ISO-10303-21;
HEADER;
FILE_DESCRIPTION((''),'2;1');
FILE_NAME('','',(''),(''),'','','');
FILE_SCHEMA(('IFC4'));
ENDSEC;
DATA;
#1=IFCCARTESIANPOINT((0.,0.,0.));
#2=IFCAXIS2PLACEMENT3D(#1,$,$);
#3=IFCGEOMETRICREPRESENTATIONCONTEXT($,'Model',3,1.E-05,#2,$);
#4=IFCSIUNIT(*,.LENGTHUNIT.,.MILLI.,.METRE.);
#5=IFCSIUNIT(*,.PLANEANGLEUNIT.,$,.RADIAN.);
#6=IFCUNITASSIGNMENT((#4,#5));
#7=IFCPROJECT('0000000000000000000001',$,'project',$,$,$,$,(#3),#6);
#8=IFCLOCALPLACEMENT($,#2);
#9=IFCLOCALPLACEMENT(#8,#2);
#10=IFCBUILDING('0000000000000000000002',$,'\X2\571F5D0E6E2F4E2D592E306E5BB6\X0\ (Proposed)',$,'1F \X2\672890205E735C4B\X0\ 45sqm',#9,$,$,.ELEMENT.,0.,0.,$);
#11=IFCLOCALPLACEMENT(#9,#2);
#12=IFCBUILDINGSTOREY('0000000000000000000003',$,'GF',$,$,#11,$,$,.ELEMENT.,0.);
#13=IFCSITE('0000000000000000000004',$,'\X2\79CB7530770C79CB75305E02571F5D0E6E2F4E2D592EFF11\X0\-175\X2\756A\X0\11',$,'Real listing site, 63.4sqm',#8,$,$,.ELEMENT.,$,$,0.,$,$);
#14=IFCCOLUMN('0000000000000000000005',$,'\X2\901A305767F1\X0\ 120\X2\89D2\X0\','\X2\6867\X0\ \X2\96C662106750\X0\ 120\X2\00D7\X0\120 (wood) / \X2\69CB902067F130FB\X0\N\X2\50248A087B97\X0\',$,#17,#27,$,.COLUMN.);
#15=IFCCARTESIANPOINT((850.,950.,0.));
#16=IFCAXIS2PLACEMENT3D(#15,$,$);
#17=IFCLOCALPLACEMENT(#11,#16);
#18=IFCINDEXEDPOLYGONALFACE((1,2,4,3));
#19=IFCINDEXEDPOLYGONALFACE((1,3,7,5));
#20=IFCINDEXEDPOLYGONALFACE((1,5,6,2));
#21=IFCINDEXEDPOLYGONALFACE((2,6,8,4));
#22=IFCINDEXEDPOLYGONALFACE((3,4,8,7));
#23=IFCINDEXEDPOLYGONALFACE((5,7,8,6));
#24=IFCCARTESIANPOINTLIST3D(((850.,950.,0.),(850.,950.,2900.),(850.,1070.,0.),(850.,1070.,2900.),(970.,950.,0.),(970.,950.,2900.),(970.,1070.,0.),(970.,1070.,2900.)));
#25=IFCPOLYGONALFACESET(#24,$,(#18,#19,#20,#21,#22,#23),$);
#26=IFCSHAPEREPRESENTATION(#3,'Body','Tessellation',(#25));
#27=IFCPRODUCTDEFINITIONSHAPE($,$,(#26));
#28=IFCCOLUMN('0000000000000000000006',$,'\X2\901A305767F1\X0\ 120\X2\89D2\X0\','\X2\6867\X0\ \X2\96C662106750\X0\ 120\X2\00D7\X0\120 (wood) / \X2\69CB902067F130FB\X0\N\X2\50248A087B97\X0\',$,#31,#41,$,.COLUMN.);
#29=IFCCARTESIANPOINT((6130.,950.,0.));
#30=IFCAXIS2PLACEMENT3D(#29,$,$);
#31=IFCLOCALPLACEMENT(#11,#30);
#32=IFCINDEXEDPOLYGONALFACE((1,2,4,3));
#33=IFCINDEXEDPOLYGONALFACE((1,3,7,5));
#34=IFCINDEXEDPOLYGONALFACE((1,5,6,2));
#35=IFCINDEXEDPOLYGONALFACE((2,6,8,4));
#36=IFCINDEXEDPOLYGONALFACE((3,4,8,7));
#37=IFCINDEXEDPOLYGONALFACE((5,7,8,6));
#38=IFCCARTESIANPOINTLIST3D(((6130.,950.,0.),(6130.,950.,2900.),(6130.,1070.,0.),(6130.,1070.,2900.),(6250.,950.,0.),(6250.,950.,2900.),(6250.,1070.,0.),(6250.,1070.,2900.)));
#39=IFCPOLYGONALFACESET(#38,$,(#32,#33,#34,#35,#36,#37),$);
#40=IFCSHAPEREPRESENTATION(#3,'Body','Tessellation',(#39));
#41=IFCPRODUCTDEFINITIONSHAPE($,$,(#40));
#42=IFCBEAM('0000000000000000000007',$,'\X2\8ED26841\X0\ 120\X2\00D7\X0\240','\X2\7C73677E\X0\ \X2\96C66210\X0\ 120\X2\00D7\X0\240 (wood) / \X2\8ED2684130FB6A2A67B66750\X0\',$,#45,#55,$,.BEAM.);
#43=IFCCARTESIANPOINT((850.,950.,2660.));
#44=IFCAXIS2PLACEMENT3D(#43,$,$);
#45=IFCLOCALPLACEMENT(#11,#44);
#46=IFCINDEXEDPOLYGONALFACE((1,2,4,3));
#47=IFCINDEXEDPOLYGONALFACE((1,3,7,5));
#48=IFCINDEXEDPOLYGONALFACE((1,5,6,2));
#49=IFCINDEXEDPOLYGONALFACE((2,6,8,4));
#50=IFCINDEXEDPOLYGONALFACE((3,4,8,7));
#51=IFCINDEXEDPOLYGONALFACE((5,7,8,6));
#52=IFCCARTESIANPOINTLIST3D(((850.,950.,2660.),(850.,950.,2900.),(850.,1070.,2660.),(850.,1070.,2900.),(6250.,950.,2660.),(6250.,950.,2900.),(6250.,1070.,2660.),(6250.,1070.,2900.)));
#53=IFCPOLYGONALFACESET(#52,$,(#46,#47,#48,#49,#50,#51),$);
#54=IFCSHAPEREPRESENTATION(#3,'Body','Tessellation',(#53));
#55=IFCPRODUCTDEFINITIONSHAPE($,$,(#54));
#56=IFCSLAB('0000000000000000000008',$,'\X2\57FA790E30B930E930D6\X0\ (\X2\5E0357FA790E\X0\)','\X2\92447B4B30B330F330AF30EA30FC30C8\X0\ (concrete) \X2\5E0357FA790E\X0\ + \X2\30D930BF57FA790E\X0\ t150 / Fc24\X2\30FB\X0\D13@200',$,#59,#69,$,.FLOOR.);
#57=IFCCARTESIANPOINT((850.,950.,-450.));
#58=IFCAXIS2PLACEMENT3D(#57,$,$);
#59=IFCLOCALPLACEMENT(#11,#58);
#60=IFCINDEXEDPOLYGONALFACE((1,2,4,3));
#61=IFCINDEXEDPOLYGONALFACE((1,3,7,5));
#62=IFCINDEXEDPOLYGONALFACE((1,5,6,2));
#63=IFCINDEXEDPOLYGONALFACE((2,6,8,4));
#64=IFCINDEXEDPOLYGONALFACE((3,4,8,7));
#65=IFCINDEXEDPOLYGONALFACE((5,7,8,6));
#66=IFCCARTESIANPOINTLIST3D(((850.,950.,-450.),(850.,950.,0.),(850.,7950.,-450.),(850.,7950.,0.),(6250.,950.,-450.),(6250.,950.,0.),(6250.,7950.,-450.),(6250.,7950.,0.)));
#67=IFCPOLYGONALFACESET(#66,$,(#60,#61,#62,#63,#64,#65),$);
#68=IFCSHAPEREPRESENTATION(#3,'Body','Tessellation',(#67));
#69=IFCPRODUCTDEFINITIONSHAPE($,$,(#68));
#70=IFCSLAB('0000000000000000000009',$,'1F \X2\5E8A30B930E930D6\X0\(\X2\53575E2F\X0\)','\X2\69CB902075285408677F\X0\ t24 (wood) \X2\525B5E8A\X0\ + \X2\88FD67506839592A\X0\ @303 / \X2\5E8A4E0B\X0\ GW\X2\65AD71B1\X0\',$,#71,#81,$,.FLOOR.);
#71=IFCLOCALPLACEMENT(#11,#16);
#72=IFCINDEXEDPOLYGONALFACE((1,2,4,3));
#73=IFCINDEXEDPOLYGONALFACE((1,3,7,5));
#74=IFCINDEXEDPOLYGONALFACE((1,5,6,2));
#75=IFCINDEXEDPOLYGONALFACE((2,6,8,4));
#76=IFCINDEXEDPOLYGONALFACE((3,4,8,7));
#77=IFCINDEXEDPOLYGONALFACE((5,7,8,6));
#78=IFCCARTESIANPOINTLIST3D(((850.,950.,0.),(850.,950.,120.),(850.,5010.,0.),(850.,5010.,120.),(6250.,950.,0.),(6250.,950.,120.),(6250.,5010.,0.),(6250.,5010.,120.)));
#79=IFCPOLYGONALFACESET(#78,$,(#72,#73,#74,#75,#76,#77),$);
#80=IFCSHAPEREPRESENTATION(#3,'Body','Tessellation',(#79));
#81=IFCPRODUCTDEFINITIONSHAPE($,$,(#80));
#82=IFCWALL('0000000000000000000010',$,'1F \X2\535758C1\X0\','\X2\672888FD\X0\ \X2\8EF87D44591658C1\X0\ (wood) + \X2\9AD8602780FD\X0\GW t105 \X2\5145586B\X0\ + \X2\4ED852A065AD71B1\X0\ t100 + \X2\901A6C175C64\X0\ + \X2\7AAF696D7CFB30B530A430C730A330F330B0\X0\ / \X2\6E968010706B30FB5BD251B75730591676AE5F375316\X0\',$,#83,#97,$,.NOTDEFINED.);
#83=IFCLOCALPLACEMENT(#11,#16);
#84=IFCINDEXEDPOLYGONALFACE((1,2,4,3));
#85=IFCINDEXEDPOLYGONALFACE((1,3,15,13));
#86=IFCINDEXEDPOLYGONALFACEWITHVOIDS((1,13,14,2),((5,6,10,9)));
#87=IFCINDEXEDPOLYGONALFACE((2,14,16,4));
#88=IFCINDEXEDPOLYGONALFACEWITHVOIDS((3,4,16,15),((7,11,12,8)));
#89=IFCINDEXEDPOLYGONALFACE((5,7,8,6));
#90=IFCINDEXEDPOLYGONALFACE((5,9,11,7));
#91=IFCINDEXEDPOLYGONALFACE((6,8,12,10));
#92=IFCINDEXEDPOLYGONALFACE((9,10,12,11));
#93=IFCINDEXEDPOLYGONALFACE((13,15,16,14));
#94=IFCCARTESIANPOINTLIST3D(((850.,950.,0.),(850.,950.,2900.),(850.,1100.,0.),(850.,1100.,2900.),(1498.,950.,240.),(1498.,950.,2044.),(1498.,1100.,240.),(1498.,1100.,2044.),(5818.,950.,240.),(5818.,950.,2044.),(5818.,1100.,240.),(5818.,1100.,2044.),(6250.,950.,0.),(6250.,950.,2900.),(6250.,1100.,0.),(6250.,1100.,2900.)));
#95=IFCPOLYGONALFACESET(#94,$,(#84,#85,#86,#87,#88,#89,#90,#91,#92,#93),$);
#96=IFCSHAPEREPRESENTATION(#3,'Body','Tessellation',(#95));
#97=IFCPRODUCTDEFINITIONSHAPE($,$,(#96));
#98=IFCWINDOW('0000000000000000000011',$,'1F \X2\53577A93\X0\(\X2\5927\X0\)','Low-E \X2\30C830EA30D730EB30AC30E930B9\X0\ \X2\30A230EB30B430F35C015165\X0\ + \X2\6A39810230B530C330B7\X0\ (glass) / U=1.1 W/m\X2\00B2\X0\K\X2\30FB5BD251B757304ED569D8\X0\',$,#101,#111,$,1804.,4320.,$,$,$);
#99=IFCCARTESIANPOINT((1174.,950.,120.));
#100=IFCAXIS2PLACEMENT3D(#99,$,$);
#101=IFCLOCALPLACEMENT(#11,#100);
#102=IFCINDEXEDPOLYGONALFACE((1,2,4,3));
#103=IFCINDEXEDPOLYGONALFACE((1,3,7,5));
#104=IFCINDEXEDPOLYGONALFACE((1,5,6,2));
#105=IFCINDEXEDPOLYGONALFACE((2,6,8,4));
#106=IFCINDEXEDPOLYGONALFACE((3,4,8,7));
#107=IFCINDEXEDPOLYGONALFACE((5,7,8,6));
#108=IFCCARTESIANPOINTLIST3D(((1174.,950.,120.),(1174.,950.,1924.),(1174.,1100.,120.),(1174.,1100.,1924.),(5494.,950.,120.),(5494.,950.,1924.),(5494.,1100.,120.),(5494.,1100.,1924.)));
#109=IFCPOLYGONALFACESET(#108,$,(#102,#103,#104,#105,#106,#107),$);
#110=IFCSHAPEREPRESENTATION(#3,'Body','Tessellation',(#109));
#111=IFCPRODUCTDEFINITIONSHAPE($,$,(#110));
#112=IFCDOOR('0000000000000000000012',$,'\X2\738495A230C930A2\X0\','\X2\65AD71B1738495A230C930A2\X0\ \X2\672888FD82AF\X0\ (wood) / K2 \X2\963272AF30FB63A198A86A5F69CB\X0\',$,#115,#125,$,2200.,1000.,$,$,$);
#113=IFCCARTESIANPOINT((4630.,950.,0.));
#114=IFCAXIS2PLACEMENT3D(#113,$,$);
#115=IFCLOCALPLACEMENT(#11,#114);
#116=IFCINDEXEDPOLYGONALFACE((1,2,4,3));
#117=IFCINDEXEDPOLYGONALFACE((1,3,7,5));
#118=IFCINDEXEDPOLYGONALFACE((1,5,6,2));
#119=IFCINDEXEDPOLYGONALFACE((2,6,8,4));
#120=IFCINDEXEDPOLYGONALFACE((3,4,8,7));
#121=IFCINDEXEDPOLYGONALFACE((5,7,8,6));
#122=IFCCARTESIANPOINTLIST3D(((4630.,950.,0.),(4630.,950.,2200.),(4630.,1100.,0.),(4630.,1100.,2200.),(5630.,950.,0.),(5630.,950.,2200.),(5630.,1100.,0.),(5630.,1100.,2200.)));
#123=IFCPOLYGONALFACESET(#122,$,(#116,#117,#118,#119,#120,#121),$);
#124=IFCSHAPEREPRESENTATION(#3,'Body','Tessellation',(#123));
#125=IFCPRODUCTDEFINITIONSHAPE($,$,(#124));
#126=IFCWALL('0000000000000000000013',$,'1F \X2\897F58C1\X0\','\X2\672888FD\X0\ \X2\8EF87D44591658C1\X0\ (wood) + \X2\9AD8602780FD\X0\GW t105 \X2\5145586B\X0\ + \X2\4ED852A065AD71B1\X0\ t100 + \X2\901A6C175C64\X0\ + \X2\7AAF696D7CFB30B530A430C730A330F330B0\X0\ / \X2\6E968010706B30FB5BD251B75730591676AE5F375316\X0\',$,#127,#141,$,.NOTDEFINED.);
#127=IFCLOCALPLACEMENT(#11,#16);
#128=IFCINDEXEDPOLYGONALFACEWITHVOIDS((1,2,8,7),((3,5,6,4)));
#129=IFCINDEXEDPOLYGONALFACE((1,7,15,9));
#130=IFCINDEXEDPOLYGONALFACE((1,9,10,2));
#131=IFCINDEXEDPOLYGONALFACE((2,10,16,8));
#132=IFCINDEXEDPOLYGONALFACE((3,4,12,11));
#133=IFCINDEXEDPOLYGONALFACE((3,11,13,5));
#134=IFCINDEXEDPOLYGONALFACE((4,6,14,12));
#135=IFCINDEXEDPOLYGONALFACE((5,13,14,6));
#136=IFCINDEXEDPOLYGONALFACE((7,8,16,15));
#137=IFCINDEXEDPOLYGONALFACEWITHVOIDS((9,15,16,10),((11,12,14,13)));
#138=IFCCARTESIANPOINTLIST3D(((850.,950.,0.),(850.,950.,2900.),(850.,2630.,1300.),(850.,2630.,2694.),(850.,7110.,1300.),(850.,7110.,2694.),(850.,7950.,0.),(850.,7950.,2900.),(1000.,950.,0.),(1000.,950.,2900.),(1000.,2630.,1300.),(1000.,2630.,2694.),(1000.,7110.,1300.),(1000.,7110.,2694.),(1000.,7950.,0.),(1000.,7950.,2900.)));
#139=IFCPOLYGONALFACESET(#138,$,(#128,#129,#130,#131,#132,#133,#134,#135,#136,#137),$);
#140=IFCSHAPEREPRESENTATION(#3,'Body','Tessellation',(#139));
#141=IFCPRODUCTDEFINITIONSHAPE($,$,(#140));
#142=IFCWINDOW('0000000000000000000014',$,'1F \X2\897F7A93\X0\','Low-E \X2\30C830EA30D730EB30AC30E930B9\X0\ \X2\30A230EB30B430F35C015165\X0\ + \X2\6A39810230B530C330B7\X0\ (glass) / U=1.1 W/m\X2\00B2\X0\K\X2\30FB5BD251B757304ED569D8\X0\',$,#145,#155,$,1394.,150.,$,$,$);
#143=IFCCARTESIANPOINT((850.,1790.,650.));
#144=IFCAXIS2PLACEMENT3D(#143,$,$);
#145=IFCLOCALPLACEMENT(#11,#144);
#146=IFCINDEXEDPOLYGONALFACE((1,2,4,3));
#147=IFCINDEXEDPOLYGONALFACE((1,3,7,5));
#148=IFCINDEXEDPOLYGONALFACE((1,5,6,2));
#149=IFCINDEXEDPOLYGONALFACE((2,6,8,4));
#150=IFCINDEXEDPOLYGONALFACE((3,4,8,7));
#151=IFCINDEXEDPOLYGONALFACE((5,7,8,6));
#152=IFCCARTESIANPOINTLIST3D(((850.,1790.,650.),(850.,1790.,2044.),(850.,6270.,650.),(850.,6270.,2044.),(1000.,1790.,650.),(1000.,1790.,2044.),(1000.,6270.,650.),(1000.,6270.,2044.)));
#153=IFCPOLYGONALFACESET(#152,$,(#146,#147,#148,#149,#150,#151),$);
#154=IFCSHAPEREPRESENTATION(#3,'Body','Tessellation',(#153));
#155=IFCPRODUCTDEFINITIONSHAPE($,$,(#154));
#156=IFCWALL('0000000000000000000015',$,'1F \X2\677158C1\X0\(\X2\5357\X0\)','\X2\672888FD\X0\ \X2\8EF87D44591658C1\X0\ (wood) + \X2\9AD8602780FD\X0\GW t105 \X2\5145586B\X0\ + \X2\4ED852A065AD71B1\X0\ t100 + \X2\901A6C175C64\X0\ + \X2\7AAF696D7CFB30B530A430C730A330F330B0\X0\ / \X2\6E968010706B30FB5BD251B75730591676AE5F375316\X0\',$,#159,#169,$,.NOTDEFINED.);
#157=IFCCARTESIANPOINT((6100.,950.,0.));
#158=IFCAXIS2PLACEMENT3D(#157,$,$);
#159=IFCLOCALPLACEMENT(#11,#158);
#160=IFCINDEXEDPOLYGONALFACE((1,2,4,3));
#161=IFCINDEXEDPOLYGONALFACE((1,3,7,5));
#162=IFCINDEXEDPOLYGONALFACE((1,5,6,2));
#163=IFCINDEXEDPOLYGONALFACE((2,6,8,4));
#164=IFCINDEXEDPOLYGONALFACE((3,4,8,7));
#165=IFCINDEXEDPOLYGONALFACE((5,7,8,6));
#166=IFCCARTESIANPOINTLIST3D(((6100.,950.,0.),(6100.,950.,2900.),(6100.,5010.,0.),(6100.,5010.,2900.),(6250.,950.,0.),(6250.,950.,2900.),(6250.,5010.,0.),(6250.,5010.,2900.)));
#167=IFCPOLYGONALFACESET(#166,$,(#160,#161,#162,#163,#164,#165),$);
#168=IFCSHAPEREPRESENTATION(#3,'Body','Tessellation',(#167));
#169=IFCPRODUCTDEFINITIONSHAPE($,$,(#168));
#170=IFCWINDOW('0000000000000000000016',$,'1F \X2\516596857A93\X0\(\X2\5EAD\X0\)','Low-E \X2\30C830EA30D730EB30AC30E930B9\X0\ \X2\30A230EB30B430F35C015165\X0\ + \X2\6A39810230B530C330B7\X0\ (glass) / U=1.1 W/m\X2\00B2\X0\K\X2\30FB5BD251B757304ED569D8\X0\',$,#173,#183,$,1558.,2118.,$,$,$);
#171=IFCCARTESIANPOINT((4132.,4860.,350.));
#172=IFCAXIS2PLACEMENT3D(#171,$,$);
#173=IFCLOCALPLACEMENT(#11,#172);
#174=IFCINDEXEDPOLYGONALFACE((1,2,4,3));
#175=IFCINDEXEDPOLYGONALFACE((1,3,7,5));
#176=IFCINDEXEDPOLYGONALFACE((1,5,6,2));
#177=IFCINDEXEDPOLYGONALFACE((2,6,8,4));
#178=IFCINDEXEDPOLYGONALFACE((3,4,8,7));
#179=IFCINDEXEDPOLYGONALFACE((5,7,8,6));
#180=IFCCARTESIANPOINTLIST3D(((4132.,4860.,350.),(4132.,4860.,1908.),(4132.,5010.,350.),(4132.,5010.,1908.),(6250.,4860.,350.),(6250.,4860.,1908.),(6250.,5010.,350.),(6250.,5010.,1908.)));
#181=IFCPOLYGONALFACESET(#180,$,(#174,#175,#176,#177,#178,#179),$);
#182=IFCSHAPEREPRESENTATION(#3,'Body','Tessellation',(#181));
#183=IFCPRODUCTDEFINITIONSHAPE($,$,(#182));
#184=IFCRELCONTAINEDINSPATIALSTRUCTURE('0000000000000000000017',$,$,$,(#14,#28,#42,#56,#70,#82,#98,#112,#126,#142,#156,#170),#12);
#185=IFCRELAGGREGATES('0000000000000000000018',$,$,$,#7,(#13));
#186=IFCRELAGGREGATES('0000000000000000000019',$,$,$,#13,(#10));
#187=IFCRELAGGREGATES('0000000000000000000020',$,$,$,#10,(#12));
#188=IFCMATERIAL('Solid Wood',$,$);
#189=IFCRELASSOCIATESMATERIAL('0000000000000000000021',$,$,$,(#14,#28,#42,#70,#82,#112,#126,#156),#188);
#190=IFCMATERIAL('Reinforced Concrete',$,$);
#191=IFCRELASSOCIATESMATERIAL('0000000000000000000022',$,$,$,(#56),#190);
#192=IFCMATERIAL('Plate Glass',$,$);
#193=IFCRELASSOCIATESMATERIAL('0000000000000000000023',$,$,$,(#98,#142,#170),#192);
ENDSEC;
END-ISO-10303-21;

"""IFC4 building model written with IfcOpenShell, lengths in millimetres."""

from ifc_helpers import new_model, si_unit, frame, frame_2d, origin, place, context, project, spatial, rectangle, extrude, material, element, fill, save


model = new_model("IFC4")

# Units and contexts
model_context = context("Model", 3, precision=1e-05, world=origin())
ifc_project = project(units=[si_unit("LENGTHUNIT", "METRE", prefix="MILLI"), si_unit("PLANEANGLEUNIT", "RADIAN")], contexts=[model_context])

# Site, building, storey
site_placement = place(None, origin())
site = spatial("IfcSite", under=ifc_project, at=site_placement, Name="秋田県秋田市土崎港中央１-175番11", ObjectType="Real listing site, 63.4sqm", CompositionType="ELEMENT", RefElevation=0.0)
building_placement = place(site_placement, origin())
building = spatial("IfcBuilding", under=site, at=building_placement, Name="土崎港中央の家 (Proposed)", ObjectType="1F 木造平屋 45sqm", CompositionType="ELEMENT", ElevationOfRefHeight=0.0, ElevationOfTerrain=0.0)
storey_placement = place(building_placement, origin())
storey = spatial("IfcBuildingStorey", under=building, at=storey_placement, Name="GF", CompositionType="ELEMENT", Elevation=0.0)

# Columns
ifc_material_1 = material(Name="Solid Wood")
column_1_placement = place(storey_placement, frame((850.0, 950.0, 0.0)))
element("IfcColumn", 1, at=column_1_placement, inside=storey, material=ifc_material_1, Name="通し柱 120角", Description="桧 集成材 120×120 (wood) / 構造柱・N値計算", PredefinedType="COLUMN", context=model_context, shape_type="SweptSolid", body=[
    extrude(rectangle(XDim=120.0, YDim=120.0, at=frame_2d((60.0, 60.0))), frame((850.0, 950.0, 0.0)), (0.0, 0.0, 1.0), 2900.0),
])
column_2_placement = place(storey_placement, frame((6130.0, 950.0, 0.0)))
element("IfcColumn", 2, at=column_2_placement, inside=storey, material=ifc_material_1, Name="通し柱 120角", Description="桧 集成材 120×120 (wood) / 構造柱・N値計算", PredefinedType="COLUMN", context=model_context, shape_type="SweptSolid", body=[
    extrude(rectangle(XDim=120.0, YDim=120.0, at=frame_2d((60.0, 60.0))), frame((6130.0, 950.0, 0.0)), (0.0, 0.0, 1.0), 2900.0),
])

# Beam
beam_1_placement = place(storey_placement, frame((850.0, 950.0, 2660.0)))
element("IfcBeam", 3, at=beam_1_placement, inside=storey, material=ifc_material_1, Name="軒桁 120×240", Description="米松 集成 120×240 (wood) / 軒桁・横架材", PredefinedType="BEAM", context=model_context, shape_type="SweptSolid", body=[
    extrude(rectangle(XDim=5400.0, YDim=120.0, at=frame_2d((2700.0, 60.0))), frame((850.0, 950.0, 2660.0)), (0.0, 0.0, 1.0), 240.0),
])

# Slabs
ifc_material_2 = material(Name="Reinforced Concrete")
slab_1_placement = place(storey_placement, frame((850.0, 950.0, -450.0)))
element("IfcSlab", 4, at=slab_1_placement, inside=storey, material=ifc_material_2, Name="基礎スラブ (布基礎)", Description="鉄筋コンクリート (concrete) 布基礎 + ベタ基礎 t150 / Fc24・D13@200", PredefinedType="FLOOR", context=model_context, shape_type="SweptSolid", body=[
    extrude(rectangle(XDim=5400.0, YDim=7000.0, at=frame_2d((2700.0, 3500.0))), frame((850.0, 950.0, -450.0)), (0.0, 0.0, 1.0), 450.0),
])
slab_2_placement = place(storey_placement, frame((850.0, 950.0, 0.0)))
element("IfcSlab", 5, at=slab_2_placement, inside=storey, material=ifc_material_1, Name="1F 床スラブ(南帯)", Description="構造用合板 t24 (wood) 剛床 + 製材根太 @303 / 床下 GW断熱", PredefinedType="FLOOR", context=model_context, shape_type="SweptSolid", body=[
    extrude(rectangle(XDim=5400.0, YDim=4060.0, at=frame_2d((2700.0, 2030.0))), frame((850.0, 950.0, 0.0)), (0.0, 0.0, 1.0), 120.0),
])

# Wall, openings, window, door
wall_1_placement = place(storey_placement, frame((850.0, 950.0, 0.0)))
wall_1 = element("IfcWall", 6, at=wall_1_placement, inside=storey, material=ifc_material_1, Name="1F 南壁", Description="木製 軸組外壁 (wood) + 高性能GW t105 充填 + 付加断熱 t100 + 通気層 + 窯業系サイディング / 準耐火・寒冷地外皮強化", PredefinedType="NOTDEFINED", context=model_context, shape_type="SweptSolid", body=[
    extrude(rectangle(XDim=5400.0, YDim=150.0, at=frame_2d((2700.0, 75.0))), frame((850.0, 950.0, 0.0)), (0.0, 0.0, 1.0), 2900.0),
])
opening_1_placement = place(storey_placement, frame((1174.0, 950.0, 120.0)))
opening_1 = element("IfcOpeningElement", 7, at=opening_1_placement, cuts=wall_1, PredefinedType="NOTDEFINED", context=model_context, shape_type="SweptSolid", body=[
    extrude(rectangle(XDim=4320.0, YDim=150.0, at=frame_2d((2160.0, 75.0))), frame((1174.0, 950.0, 120.0)), (0.0, 0.0, 1.0), 1804.0),
])
opening_2_placement = place(storey_placement, frame((4630.0, 950.0, 0.0)))
opening_2 = element("IfcOpeningElement", 8, at=opening_2_placement, cuts=wall_1, PredefinedType="NOTDEFINED", context=model_context, shape_type="SweptSolid", body=[
    extrude(rectangle(XDim=1000.0, YDim=150.0, at=frame_2d((500.0, 75.0))), frame((4630.0, 950.0, 0.0)), (0.0, 0.0, 1.0), 2200.0),
])
ifc_material_3 = material(Name="Plate Glass")
window_1_placement = place(storey_placement, frame((1174.0, 950.0, 120.0)))
window_1 = element("IfcWindow", 9, at=window_1_placement, inside=storey, material=ifc_material_3, Name="1F 南窓(大)", Description="Low-E トリプルガラス アルゴン封入 + 樹脂サッシ (glass) / U=1.1 W/m²K・寒冷地仕様", OverallHeight=1804.0, OverallWidth=4320.0, context=model_context, shape_type="SweptSolid", body=[
    extrude(rectangle(XDim=4320.0, YDim=150.0, at=frame_2d((2160.0, 75.0))), frame((1174.0, 950.0, 120.0)), (0.0, 0.0, 1.0), 1804.0),
])
fill(opening_1, window_1)
door_1_placement = place(storey_placement, frame((4630.0, 950.0, 0.0)))
door_1 = element("IfcDoor", 10, at=door_1_placement, inside=storey, material=ifc_material_1, Name="玄関ドア", Description="断熱玄関ドア 木製芯 (wood) / K2 防犯・採風機構", OverallHeight=2200.0, OverallWidth=1000.0, context=model_context, shape_type="SweptSolid", body=[
    extrude(rectangle(XDim=1000.0, YDim=150.0, at=frame_2d((500.0, 75.0))), frame((4630.0, 950.0, 0.0)), (0.0, 0.0, 1.0), 2200.0),
])
fill(opening_2, door_1)

# Walls, openings, windows
wall_2_placement = place(storey_placement, frame((850.0, 950.0, 0.0)))
wall_2 = element("IfcWall", 11, at=wall_2_placement, inside=storey, material=ifc_material_1, Name="1F 西壁", Description="木製 軸組外壁 (wood) + 高性能GW t105 充填 + 付加断熱 t100 + 通気層 + 窯業系サイディング / 準耐火・寒冷地外皮強化", PredefinedType="NOTDEFINED", context=model_context, shape_type="SweptSolid", body=[
    extrude(rectangle(XDim=150.0, YDim=7000.0, at=frame_2d((75.0, 3500.0))), frame((850.0, 950.0, 0.0)), (0.0, 0.0, 1.0), 2900.0),
])
opening_3_placement = place(storey_placement, frame((850.0, 1790.0, 650.0)))
opening_3 = element("IfcOpeningElement", 12, at=opening_3_placement, cuts=wall_2, PredefinedType="NOTDEFINED", context=model_context, shape_type="SweptSolid", body=[
    extrude(rectangle(XDim=150.0, YDim=4480.0, at=frame_2d((75.0, 2240.0))), frame((850.0, 1790.0, 650.0)), (0.0, 0.0, 1.0), 1394.0),
])
window_2_placement = place(storey_placement, frame((850.0, 1790.0, 650.0)))
window_2 = element("IfcWindow", 13, at=window_2_placement, inside=storey, material=ifc_material_3, Name="1F 西窓", Description="Low-E トリプルガラス アルゴン封入 + 樹脂サッシ (glass) / U=1.1 W/m²K・寒冷地仕様", OverallHeight=1394.0, OverallWidth=150.0, context=model_context, shape_type="SweptSolid", body=[
    extrude(rectangle(XDim=150.0, YDim=4480.0, at=frame_2d((75.0, 2240.0))), frame((850.0, 1790.0, 650.0)), (0.0, 0.0, 1.0), 1394.0),
])
fill(opening_3, window_2)
wall_3_placement = place(storey_placement, frame((6100.0, 950.0, 0.0)))
wall_3 = element("IfcWall", 14, at=wall_3_placement, inside=storey, material=ifc_material_1, Name="1F 東壁(南)", Description="木製 軸組外壁 (wood) + 高性能GW t105 充填 + 付加断熱 t100 + 通気層 + 窯業系サイディング / 準耐火・寒冷地外皮強化", PredefinedType="NOTDEFINED", context=model_context, shape_type="SweptSolid", body=[
    extrude(rectangle(XDim=150.0, YDim=4060.0, at=frame_2d((75.0, 2030.0))), frame((6100.0, 950.0, 0.0)), (0.0, 0.0, 1.0), 2900.0),
])
opening_4_placement = place(storey_placement, frame((4132.0, 4860.0, 350.0)))
opening_4 = element("IfcOpeningElement", 15, at=opening_4_placement, cuts=wall_3, PredefinedType="NOTDEFINED", context=model_context, shape_type="SweptSolid", body=[
    extrude(rectangle(XDim=2118.0, YDim=150.0, at=frame_2d((1059.0, 75.0))), frame((4132.0, 4860.0, 350.0)), (0.0, 0.0, 1.0), 1558.0),
])
window_3_placement = place(storey_placement, frame((4132.0, 4860.0, 350.0)))
window_3 = element("IfcWindow", 16, at=window_3_placement, inside=storey, material=ifc_material_3, Name="1F 入隅窓(庭)", Description="Low-E トリプルガラス アルゴン封入 + 樹脂サッシ (glass) / U=1.1 W/m²K・寒冷地仕様", OverallHeight=1558.0, OverallWidth=2118.0, context=model_context, shape_type="SweptSolid", body=[
    extrude(rectangle(XDim=2118.0, YDim=150.0, at=frame_2d((1059.0, 75.0))), frame((4132.0, 4860.0, 350.0)), (0.0, 0.0, 1.0), 1558.0),
])
fill(opening_4, window_3)

save(model, "model.ifc")
